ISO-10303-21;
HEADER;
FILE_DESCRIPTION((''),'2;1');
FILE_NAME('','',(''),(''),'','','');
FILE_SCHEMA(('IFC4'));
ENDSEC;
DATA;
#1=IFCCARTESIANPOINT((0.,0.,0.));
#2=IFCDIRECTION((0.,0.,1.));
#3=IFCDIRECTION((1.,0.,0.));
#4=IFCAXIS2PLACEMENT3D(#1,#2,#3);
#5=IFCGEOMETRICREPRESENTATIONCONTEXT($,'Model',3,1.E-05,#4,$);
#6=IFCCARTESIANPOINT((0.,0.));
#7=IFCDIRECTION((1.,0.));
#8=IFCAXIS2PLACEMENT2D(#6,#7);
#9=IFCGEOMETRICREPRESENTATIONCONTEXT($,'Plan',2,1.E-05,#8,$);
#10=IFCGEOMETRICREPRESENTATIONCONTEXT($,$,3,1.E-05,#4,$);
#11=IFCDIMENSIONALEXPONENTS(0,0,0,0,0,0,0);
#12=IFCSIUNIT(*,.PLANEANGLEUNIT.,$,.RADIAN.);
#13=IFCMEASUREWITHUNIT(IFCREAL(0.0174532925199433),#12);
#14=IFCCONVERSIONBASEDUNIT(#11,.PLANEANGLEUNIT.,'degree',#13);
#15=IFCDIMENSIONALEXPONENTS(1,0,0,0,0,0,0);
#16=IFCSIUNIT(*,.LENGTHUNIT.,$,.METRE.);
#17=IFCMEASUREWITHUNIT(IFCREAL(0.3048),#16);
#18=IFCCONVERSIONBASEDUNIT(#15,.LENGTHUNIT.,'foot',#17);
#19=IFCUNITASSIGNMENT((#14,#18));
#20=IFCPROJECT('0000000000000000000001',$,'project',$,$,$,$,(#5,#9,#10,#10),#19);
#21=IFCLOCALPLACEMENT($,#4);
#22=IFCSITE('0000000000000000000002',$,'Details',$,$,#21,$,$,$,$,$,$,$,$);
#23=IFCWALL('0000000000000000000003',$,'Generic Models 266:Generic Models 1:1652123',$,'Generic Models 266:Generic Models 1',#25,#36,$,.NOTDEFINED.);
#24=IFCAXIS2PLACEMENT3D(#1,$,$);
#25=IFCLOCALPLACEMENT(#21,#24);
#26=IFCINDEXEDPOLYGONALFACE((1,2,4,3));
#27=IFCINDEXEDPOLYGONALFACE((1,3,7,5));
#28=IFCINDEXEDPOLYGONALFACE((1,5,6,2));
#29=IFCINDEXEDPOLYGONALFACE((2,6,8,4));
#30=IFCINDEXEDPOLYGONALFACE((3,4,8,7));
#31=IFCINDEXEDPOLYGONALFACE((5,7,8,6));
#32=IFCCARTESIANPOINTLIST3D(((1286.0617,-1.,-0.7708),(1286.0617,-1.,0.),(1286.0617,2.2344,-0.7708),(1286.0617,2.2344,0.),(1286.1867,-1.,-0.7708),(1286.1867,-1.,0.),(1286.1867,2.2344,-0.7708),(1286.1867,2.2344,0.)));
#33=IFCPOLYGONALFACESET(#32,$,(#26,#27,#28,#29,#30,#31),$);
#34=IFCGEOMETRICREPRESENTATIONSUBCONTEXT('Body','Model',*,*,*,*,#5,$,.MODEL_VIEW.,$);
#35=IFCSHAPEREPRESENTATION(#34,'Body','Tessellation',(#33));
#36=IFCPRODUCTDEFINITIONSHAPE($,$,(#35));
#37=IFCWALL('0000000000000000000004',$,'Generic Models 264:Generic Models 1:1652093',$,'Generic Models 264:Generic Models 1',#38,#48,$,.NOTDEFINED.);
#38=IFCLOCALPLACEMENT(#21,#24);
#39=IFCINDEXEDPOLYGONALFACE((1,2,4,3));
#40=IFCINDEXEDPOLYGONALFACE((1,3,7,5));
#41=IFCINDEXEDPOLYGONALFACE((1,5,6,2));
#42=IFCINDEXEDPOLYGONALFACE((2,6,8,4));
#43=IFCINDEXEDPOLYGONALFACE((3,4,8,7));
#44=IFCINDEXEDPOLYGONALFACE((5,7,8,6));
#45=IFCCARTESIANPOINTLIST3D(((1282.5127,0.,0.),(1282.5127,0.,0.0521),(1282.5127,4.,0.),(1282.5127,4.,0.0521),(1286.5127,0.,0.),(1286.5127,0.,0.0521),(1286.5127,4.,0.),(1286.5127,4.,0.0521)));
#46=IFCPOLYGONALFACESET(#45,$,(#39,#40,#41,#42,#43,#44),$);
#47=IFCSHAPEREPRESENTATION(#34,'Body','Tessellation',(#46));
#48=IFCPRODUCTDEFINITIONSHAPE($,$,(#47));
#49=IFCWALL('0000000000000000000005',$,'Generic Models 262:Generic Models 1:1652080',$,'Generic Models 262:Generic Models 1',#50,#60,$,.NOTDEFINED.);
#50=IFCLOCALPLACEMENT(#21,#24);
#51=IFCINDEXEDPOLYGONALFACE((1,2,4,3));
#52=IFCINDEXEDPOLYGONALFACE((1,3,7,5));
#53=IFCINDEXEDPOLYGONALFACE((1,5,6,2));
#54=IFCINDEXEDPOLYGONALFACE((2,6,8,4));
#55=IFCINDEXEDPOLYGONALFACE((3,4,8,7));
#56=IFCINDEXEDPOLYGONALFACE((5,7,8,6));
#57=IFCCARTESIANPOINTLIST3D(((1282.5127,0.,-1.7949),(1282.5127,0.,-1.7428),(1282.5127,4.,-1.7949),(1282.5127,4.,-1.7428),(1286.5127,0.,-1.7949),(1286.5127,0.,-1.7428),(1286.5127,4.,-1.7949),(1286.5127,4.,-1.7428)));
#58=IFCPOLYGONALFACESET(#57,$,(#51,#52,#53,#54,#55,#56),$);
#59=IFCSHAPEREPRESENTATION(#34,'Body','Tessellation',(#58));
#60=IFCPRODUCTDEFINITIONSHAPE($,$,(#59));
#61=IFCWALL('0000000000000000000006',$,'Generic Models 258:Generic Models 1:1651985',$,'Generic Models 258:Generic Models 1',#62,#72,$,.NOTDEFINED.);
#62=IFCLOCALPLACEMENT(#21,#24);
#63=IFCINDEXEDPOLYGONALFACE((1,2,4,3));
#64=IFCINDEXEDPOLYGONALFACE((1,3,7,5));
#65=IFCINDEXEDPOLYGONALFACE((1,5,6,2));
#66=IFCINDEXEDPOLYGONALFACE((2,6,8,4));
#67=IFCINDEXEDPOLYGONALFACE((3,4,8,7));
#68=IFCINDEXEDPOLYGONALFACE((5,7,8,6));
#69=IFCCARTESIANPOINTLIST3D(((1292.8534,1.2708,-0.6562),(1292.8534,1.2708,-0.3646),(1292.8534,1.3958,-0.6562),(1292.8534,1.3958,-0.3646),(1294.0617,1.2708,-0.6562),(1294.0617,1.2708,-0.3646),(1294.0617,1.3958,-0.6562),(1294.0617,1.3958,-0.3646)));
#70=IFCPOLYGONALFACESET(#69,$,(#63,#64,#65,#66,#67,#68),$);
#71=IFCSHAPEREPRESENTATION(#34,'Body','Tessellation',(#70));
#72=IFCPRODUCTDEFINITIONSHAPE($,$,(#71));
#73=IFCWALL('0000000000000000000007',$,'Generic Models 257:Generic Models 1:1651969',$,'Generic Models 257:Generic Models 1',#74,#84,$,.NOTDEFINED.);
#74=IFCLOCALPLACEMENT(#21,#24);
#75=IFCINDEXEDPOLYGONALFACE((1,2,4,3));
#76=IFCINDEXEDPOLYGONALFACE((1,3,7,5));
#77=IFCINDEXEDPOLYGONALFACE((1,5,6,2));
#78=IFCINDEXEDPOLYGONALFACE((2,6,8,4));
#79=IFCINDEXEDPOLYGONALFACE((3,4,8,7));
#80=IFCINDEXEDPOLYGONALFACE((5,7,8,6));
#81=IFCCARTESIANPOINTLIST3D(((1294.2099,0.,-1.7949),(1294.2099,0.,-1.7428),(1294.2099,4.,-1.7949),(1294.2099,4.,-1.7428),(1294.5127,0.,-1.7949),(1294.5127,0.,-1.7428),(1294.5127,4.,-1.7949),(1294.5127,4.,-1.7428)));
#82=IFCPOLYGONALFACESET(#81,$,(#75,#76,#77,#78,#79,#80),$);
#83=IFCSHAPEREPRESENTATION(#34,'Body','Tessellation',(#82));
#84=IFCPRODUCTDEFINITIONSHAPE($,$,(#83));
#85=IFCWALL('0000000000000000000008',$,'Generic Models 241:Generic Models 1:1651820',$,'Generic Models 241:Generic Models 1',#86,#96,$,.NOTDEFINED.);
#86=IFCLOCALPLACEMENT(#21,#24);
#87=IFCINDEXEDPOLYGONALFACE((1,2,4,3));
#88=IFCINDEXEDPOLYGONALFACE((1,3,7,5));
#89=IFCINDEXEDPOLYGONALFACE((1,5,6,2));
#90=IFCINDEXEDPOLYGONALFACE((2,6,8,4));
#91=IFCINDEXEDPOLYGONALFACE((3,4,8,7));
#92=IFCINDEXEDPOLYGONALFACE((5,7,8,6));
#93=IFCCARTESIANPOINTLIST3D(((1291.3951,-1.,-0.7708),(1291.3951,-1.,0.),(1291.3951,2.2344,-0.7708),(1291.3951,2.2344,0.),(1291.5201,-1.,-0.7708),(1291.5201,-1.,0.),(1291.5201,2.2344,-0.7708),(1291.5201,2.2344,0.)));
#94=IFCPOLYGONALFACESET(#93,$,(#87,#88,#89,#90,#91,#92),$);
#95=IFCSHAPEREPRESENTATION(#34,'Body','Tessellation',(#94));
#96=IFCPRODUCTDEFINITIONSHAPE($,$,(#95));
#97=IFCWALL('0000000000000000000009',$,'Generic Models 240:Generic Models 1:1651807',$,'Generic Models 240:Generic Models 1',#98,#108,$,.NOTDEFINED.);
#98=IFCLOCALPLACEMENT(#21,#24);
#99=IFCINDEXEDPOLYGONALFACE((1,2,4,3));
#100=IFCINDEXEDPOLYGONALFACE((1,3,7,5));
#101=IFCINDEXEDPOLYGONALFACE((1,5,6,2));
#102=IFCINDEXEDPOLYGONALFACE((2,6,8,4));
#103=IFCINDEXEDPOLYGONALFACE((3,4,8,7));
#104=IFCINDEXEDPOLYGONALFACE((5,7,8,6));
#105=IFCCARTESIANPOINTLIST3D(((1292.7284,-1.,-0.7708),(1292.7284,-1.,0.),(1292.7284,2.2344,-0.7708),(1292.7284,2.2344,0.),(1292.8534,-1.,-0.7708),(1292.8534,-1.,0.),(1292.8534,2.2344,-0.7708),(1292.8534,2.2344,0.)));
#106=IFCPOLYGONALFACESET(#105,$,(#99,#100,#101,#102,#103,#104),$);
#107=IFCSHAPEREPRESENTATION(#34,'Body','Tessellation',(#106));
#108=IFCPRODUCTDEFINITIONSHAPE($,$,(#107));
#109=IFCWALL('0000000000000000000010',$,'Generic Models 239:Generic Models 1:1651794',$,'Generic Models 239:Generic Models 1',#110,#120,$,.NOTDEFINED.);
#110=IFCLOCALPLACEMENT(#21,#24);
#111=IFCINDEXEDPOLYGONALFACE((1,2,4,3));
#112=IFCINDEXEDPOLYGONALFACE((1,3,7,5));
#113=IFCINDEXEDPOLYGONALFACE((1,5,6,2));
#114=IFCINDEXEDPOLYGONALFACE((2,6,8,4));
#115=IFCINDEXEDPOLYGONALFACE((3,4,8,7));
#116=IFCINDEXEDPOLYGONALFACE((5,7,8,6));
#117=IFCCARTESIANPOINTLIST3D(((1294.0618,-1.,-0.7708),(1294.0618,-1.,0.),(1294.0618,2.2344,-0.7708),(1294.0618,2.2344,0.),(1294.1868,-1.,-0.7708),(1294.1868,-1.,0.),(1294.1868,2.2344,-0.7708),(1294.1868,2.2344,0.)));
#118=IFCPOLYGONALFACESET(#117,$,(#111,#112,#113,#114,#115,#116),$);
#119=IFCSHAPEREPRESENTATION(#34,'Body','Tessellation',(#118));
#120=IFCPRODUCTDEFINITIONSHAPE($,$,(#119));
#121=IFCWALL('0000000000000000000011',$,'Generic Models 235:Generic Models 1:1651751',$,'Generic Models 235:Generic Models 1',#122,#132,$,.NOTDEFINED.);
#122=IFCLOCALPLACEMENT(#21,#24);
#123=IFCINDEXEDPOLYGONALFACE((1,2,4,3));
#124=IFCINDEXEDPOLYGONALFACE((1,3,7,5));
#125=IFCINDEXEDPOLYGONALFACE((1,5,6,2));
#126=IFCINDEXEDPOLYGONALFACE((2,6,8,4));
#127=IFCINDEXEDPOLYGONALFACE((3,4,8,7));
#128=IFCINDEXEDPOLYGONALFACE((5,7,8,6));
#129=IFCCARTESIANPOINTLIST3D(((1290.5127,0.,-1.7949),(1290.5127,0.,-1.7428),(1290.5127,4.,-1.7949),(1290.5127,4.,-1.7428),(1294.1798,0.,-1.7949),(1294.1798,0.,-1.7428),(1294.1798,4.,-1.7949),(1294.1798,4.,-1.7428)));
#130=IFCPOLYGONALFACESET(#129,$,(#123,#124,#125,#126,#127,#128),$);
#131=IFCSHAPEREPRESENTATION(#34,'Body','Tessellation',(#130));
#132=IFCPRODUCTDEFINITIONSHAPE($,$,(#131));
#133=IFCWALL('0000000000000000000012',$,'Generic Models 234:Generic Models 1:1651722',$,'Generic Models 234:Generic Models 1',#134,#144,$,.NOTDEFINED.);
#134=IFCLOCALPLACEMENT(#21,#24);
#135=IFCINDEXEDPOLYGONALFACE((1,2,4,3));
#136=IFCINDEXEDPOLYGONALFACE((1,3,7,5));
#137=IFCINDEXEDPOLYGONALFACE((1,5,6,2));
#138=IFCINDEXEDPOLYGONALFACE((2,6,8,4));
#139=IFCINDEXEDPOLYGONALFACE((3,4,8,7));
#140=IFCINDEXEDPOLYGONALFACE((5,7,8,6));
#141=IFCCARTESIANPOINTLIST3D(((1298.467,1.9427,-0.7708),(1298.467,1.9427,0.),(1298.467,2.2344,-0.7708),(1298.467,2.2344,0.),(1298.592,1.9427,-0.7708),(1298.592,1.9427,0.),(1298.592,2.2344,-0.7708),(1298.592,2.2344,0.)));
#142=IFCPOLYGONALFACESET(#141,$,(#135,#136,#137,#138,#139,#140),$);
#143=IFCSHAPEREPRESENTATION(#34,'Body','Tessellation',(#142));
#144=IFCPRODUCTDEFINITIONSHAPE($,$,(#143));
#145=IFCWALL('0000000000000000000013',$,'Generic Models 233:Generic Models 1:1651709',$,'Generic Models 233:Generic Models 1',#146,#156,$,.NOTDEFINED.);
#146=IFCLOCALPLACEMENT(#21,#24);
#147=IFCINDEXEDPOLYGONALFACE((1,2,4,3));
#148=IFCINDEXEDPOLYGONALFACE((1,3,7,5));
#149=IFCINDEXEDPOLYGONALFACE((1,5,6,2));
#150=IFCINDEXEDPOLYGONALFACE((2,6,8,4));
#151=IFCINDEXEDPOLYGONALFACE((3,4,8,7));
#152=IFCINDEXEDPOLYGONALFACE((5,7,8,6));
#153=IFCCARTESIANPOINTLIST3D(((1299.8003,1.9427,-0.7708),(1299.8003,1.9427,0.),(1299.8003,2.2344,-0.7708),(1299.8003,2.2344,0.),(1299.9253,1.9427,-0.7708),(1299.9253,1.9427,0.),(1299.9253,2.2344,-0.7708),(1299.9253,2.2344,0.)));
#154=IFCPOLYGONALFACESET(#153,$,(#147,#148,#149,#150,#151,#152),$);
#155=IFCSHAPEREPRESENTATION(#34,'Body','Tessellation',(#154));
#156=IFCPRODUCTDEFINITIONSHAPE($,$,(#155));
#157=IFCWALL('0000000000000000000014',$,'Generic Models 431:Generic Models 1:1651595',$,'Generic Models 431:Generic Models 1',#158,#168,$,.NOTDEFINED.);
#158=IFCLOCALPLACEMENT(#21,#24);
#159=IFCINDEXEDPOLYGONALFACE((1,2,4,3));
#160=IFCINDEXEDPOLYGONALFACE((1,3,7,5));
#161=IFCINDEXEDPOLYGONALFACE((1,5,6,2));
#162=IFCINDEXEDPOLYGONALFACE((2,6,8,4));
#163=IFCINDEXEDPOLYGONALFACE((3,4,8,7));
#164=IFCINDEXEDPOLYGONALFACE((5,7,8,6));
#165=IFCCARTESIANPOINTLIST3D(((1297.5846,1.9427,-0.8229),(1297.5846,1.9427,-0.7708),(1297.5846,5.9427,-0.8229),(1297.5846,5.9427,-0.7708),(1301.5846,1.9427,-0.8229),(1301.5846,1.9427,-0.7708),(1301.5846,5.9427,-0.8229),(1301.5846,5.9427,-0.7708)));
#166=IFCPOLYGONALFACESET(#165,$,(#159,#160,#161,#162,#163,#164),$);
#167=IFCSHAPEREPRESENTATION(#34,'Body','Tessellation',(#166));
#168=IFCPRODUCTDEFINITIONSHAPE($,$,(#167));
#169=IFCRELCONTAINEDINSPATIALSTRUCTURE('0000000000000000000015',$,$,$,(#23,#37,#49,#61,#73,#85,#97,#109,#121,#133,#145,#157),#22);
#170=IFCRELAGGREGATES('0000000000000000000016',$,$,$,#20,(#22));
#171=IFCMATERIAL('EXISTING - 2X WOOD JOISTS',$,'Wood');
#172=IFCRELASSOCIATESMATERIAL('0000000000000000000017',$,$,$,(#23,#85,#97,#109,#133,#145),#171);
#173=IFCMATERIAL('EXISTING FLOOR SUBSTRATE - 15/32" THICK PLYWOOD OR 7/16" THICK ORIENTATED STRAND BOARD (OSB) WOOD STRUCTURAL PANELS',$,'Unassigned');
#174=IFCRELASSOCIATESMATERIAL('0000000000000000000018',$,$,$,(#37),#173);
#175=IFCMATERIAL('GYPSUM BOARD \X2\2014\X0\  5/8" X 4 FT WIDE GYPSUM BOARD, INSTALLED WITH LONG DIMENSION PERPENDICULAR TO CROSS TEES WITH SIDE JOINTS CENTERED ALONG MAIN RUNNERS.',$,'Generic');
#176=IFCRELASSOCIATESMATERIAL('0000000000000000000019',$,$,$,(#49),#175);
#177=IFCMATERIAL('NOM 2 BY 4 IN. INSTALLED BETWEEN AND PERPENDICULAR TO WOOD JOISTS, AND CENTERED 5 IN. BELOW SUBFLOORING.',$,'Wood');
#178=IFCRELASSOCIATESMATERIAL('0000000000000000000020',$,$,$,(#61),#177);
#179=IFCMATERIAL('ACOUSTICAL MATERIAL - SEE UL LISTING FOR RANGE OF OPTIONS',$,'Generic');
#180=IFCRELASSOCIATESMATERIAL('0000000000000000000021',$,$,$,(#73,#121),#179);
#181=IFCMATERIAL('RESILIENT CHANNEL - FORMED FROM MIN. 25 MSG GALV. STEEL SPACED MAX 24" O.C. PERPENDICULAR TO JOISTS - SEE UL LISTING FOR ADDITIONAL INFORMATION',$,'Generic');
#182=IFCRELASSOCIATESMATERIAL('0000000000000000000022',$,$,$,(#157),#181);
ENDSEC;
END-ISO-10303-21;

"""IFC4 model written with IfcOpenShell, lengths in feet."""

from ifc_helpers import new_model, entity, si_unit, converted_unit, frame, frame_2d, origin_with_axes, origin_2d_with_axis, place, context, subcontext, project, spatial, rectangle, extrude, material, element, save


model = new_model("IFC4")

# Units and contexts
model_context = context("Model", 3, precision=1e-05, world=origin_with_axes())
plan_context = context("Plan", 2, precision=1e-05, world=origin_2d_with_axis())
context_of_model = context(None, 3, precision=1e-05, world=origin_with_axes())
body_context = subcontext(model_context, "Body", "Model", "MODEL_VIEW")
ifc_project = project(units=[converted_unit("PLANEANGLEUNIT", "degree", entity("IfcReal", 0.0174532925199433), si_unit("PLANEANGLEUNIT", "RADIAN"), dimensions=[0, 0, 0, 0, 0, 0, 0]), converted_unit("LENGTHUNIT", "foot", entity("IfcReal", 0.3048), si_unit("LENGTHUNIT", "METRE"), dimensions=[1, 0, 0, 0, 0, 0, 0])], contexts=[model_context, plan_context, context_of_model, context_of_model])

# Site
site_placement = place(None, origin_with_axes())
site = spatial("IfcSite", under=ifc_project, at=site_placement, Name="Details")

# Walls
ifc_material_1 = material(Name="NOM 2 BY 4 IN. INSTALLED BETWEEN AND PERPENDICULAR TO WOOD JOISTS, AND CENTERED 5 IN. BELOW SUBFLOORING.", Category="Wood")
ifc_material_2 = material(Name="EXISTING - 2X WOOD JOISTS", Category="Wood")
wall_1_placement = place(site_placement, frame((1286.0617, -1.0, -0.7708), z_axis=(0.0, 0.0, 1.0), x_axis=(0.0, 1.0, 0.0)))
element("IfcWall", 1, at=wall_1_placement, inside=site, material=ifc_material_2, Name="Generic Models 266:Generic Models 1:1652123", ObjectType="Generic Models 266:Generic Models 1", PredefinedType="NOTDEFINED", context=body_context, shape_type="SweptSolid", body=[
    extrude(rectangle(XDim=3.2344, YDim=0.125, at=frame_2d((0.0, 0.0), x_axis=(1.0, 0.0))), frame((1.6172, -0.0625, 0.0)), (0.0, 0.0, 1.0), 0.7708),
])
ifc_material_3 = material(Name="EXISTING FLOOR SUBSTRATE - 15/32\" THICK PLYWOOD OR 7/16\" THICK ORIENTATED STRAND BOARD (OSB) WOOD STRUCTURAL PANELS", Category="Unassigned")
wall_2_placement = place(site_placement, frame((1282.5127, 0.0, 0.0), z_axis=(0.0, 0.0, 1.0), x_axis=(0.0, 1.0, 0.0)))
element("IfcWall", 2, at=wall_2_placement, inside=site, material=ifc_material_3, Name="Generic Models 264:Generic Models 1:1652093", ObjectType="Generic Models 264:Generic Models 1", PredefinedType="NOTDEFINED", context=body_context, shape_type="SweptSolid", body=[
    extrude(rectangle(XDim=4.0, YDim=4.0, at=origin_2d_with_axis()), frame((2.0, -2.0, 0.0)), (0.0, 0.0, 1.0), 0.0521),
])
ifc_material_4 = material(Name="GYPSUM BOARD —  5/8\" X 4 FT WIDE GYPSUM BOARD, INSTALLED WITH LONG DIMENSION PERPENDICULAR TO CROSS TEES WITH SIDE JOINTS CENTERED ALONG MAIN RUNNERS.", Category="Generic")
wall_3_placement = place(site_placement, frame((1282.5127, 0.0, -1.7949), z_axis=(0.0, 0.0, 1.0), x_axis=(0.0, 1.0, 0.0)))
element("IfcWall", 3, at=wall_3_placement, inside=site, material=ifc_material_4, Name="Generic Models 262:Generic Models 1:1652080", ObjectType="Generic Models 262:Generic Models 1", PredefinedType="NOTDEFINED", context=body_context, shape_type="SweptSolid", body=[
    extrude(rectangle(XDim=4.0, YDim=4.0, at=origin_2d_with_axis()), frame((2.0, -2.0, 0.0)), (0.0, 0.0, 1.0), 0.0521),
])
wall_4_placement = place(site_placement, frame((1292.8534, 1.2708, -0.6562), z_axis=(0.0, 0.0, 1.0), x_axis=(1.0, 0.0, 0.0)))
element("IfcWall", 4, at=wall_4_placement, inside=site, material=ifc_material_1, Name="Generic Models 258:Generic Models 1:1651985", ObjectType="Generic Models 258:Generic Models 1", PredefinedType="NOTDEFINED", context=body_context, shape_type="SweptSolid", body=[
    extrude(rectangle(XDim=0.125, YDim=1.2083, at=frame_2d((0.0, 0.0), x_axis=(1.0, 0.0))), frame((0.6042, 0.0625, 0.0), z_axis=(0.0, 0.0, 1.0), x_axis=(0.0, 1.0, 0.0)), (0.0, 0.0, 1.0), 0.2917),
])
ifc_material_5 = material(Name="ACOUSTICAL MATERIAL - SEE UL LISTING FOR RANGE OF OPTIONS", Category="Generic")
wall_5_placement = place(site_placement, frame((1294.2099, 0.0, -1.7949), z_axis=(0.0, 0.0, 1.0), x_axis=(0.0, 1.0, 0.0)))
element("IfcWall", 5, at=wall_5_placement, inside=site, material=ifc_material_5, Name="Generic Models 257:Generic Models 1:1651969", ObjectType="Generic Models 257:Generic Models 1", PredefinedType="NOTDEFINED", context=body_context, shape_type="SweptSolid", body=[
    extrude(rectangle(XDim=4.0, YDim=0.3027, at=frame_2d((0.0, 0.0), x_axis=(1.0, 0.0))), frame((2.0, -0.1514, 0.0)), (0.0, 0.0, 1.0), 0.0521),
])
wall_6_placement = place(site_placement, frame((1291.3951, -1.0, -0.7708), z_axis=(0.0, 0.0, 1.0), x_axis=(0.0, 1.0, 0.0)))
element("IfcWall", 6, at=wall_6_placement, inside=site, material=ifc_material_2, Name="Generic Models 241:Generic Models 1:1651820", ObjectType="Generic Models 241:Generic Models 1", PredefinedType="NOTDEFINED", context=body_context, shape_type="SweptSolid", body=[
    extrude(rectangle(XDim=3.2344, YDim=0.125, at=frame_2d((0.0, 0.0), x_axis=(1.0, 0.0))), frame((1.6172, -0.0625, 0.0)), (0.0, 0.0, 1.0), 0.7708),
])
wall_7_placement = place(site_placement, frame((1292.7284, -1.0, -0.7708), z_axis=(0.0, 0.0, 1.0), x_axis=(0.0, 1.0, 0.0)))
element("IfcWall", 7, at=wall_7_placement, inside=site, material=ifc_material_2, Name="Generic Models 240:Generic Models 1:1651807", ObjectType="Generic Models 240:Generic Models 1", PredefinedType="NOTDEFINED", context=body_context, shape_type="SweptSolid", body=[
    extrude(rectangle(XDim=3.2344, YDim=0.125, at=frame_2d((0.0, 0.0), x_axis=(1.0, 0.0))), frame((1.6172, -0.0625, 0.0)), (0.0, 0.0, 1.0), 0.7708),
])
wall_8_placement = place(site_placement, frame((1294.0618, -1.0, -0.7708), z_axis=(0.0, 0.0, 1.0), x_axis=(0.0, 1.0, 0.0)))
element("IfcWall", 8, at=wall_8_placement, inside=site, material=ifc_material_2, Name="Generic Models 239:Generic Models 1:1651794", ObjectType="Generic Models 239:Generic Models 1", PredefinedType="NOTDEFINED", context=body_context, shape_type="SweptSolid", body=[
    extrude(rectangle(XDim=3.2344, YDim=0.125, at=frame_2d((0.0, 0.0), x_axis=(1.0, 0.0))), frame((1.6172, -0.0625, 0.0)), (0.0, 0.0, 1.0), 0.7708),
])
wall_9_placement = place(site_placement, frame((1290.5127, 0.0, -1.7949), z_axis=(0.0, 0.0, 1.0), x_axis=(0.0, 1.0, 0.0)))
element("IfcWall", 9, at=wall_9_placement, inside=site, material=ifc_material_5, Name="Generic Models 235:Generic Models 1:1651751", ObjectType="Generic Models 235:Generic Models 1", PredefinedType="NOTDEFINED", context=body_context, shape_type="SweptSolid", body=[
    extrude(rectangle(XDim=4.0, YDim=3.6671, at=frame_2d((0.0, 0.0), x_axis=(1.0, 0.0))), frame((2.0, -1.8336, 0.0)), (0.0, 0.0, 1.0), 0.0521),
])
wall_10_placement = place(site_placement, frame((1298.467, 1.9427, -0.7708), z_axis=(0.0, 0.0, 1.0), x_axis=(0.0, 1.0, 0.0)))
element("IfcWall", 10, at=wall_10_placement, inside=site, material=ifc_material_2, Name="Generic Models 234:Generic Models 1:1651722", ObjectType="Generic Models 234:Generic Models 1", PredefinedType="NOTDEFINED", context=body_context, shape_type="SweptSolid", body=[
    extrude(rectangle(XDim=0.2917, YDim=0.125, at=frame_2d((0.0, 0.0), x_axis=(1.0, 0.0))), frame((0.1458, -0.0625, 0.0)), (0.0, 0.0, 1.0), 0.7708),
])
wall_11_placement = place(site_placement, frame((1299.8003, 1.9427, -0.7708), z_axis=(0.0, 0.0, 1.0), x_axis=(0.0, 1.0, 0.0)))
element("IfcWall", 11, at=wall_11_placement, inside=site, material=ifc_material_2, Name="Generic Models 233:Generic Models 1:1651709", ObjectType="Generic Models 233:Generic Models 1", PredefinedType="NOTDEFINED", context=body_context, shape_type="SweptSolid", body=[
    extrude(rectangle(XDim=0.2917, YDim=0.125, at=frame_2d((0.0, 0.0), x_axis=(1.0, 0.0))), frame((0.1458, -0.0625, 0.0)), (0.0, 0.0, 1.0), 0.7708),
])
ifc_material_6 = material(Name="RESILIENT CHANNEL - FORMED FROM MIN. 25 MSG GALV. STEEL SPACED MAX 24\" O.C. PERPENDICULAR TO JOISTS - SEE UL LISTING FOR ADDITIONAL INFORMATION", Category="Generic")
wall_12_placement = place(site_placement, frame((1297.5846, 1.9427, -0.8229), z_axis=(0.0, 0.0, 1.0), x_axis=(0.0, 1.0, 0.0)))
element("IfcWall", 12, at=wall_12_placement, inside=site, material=ifc_material_6, Name="Generic Models 431:Generic Models 1:1651595", ObjectType="Generic Models 431:Generic Models 1", PredefinedType="NOTDEFINED", context=body_context, shape_type="SweptSolid", body=[
    extrude(rectangle(XDim=4.0, YDim=4.0, at=frame_2d((0.0, 0.0), x_axis=(1.0, 0.0))), frame((2.0, -2.0, 0.0)), (0.0, 0.0, 1.0), 0.0521),
])

save(model, "model.ifc")
